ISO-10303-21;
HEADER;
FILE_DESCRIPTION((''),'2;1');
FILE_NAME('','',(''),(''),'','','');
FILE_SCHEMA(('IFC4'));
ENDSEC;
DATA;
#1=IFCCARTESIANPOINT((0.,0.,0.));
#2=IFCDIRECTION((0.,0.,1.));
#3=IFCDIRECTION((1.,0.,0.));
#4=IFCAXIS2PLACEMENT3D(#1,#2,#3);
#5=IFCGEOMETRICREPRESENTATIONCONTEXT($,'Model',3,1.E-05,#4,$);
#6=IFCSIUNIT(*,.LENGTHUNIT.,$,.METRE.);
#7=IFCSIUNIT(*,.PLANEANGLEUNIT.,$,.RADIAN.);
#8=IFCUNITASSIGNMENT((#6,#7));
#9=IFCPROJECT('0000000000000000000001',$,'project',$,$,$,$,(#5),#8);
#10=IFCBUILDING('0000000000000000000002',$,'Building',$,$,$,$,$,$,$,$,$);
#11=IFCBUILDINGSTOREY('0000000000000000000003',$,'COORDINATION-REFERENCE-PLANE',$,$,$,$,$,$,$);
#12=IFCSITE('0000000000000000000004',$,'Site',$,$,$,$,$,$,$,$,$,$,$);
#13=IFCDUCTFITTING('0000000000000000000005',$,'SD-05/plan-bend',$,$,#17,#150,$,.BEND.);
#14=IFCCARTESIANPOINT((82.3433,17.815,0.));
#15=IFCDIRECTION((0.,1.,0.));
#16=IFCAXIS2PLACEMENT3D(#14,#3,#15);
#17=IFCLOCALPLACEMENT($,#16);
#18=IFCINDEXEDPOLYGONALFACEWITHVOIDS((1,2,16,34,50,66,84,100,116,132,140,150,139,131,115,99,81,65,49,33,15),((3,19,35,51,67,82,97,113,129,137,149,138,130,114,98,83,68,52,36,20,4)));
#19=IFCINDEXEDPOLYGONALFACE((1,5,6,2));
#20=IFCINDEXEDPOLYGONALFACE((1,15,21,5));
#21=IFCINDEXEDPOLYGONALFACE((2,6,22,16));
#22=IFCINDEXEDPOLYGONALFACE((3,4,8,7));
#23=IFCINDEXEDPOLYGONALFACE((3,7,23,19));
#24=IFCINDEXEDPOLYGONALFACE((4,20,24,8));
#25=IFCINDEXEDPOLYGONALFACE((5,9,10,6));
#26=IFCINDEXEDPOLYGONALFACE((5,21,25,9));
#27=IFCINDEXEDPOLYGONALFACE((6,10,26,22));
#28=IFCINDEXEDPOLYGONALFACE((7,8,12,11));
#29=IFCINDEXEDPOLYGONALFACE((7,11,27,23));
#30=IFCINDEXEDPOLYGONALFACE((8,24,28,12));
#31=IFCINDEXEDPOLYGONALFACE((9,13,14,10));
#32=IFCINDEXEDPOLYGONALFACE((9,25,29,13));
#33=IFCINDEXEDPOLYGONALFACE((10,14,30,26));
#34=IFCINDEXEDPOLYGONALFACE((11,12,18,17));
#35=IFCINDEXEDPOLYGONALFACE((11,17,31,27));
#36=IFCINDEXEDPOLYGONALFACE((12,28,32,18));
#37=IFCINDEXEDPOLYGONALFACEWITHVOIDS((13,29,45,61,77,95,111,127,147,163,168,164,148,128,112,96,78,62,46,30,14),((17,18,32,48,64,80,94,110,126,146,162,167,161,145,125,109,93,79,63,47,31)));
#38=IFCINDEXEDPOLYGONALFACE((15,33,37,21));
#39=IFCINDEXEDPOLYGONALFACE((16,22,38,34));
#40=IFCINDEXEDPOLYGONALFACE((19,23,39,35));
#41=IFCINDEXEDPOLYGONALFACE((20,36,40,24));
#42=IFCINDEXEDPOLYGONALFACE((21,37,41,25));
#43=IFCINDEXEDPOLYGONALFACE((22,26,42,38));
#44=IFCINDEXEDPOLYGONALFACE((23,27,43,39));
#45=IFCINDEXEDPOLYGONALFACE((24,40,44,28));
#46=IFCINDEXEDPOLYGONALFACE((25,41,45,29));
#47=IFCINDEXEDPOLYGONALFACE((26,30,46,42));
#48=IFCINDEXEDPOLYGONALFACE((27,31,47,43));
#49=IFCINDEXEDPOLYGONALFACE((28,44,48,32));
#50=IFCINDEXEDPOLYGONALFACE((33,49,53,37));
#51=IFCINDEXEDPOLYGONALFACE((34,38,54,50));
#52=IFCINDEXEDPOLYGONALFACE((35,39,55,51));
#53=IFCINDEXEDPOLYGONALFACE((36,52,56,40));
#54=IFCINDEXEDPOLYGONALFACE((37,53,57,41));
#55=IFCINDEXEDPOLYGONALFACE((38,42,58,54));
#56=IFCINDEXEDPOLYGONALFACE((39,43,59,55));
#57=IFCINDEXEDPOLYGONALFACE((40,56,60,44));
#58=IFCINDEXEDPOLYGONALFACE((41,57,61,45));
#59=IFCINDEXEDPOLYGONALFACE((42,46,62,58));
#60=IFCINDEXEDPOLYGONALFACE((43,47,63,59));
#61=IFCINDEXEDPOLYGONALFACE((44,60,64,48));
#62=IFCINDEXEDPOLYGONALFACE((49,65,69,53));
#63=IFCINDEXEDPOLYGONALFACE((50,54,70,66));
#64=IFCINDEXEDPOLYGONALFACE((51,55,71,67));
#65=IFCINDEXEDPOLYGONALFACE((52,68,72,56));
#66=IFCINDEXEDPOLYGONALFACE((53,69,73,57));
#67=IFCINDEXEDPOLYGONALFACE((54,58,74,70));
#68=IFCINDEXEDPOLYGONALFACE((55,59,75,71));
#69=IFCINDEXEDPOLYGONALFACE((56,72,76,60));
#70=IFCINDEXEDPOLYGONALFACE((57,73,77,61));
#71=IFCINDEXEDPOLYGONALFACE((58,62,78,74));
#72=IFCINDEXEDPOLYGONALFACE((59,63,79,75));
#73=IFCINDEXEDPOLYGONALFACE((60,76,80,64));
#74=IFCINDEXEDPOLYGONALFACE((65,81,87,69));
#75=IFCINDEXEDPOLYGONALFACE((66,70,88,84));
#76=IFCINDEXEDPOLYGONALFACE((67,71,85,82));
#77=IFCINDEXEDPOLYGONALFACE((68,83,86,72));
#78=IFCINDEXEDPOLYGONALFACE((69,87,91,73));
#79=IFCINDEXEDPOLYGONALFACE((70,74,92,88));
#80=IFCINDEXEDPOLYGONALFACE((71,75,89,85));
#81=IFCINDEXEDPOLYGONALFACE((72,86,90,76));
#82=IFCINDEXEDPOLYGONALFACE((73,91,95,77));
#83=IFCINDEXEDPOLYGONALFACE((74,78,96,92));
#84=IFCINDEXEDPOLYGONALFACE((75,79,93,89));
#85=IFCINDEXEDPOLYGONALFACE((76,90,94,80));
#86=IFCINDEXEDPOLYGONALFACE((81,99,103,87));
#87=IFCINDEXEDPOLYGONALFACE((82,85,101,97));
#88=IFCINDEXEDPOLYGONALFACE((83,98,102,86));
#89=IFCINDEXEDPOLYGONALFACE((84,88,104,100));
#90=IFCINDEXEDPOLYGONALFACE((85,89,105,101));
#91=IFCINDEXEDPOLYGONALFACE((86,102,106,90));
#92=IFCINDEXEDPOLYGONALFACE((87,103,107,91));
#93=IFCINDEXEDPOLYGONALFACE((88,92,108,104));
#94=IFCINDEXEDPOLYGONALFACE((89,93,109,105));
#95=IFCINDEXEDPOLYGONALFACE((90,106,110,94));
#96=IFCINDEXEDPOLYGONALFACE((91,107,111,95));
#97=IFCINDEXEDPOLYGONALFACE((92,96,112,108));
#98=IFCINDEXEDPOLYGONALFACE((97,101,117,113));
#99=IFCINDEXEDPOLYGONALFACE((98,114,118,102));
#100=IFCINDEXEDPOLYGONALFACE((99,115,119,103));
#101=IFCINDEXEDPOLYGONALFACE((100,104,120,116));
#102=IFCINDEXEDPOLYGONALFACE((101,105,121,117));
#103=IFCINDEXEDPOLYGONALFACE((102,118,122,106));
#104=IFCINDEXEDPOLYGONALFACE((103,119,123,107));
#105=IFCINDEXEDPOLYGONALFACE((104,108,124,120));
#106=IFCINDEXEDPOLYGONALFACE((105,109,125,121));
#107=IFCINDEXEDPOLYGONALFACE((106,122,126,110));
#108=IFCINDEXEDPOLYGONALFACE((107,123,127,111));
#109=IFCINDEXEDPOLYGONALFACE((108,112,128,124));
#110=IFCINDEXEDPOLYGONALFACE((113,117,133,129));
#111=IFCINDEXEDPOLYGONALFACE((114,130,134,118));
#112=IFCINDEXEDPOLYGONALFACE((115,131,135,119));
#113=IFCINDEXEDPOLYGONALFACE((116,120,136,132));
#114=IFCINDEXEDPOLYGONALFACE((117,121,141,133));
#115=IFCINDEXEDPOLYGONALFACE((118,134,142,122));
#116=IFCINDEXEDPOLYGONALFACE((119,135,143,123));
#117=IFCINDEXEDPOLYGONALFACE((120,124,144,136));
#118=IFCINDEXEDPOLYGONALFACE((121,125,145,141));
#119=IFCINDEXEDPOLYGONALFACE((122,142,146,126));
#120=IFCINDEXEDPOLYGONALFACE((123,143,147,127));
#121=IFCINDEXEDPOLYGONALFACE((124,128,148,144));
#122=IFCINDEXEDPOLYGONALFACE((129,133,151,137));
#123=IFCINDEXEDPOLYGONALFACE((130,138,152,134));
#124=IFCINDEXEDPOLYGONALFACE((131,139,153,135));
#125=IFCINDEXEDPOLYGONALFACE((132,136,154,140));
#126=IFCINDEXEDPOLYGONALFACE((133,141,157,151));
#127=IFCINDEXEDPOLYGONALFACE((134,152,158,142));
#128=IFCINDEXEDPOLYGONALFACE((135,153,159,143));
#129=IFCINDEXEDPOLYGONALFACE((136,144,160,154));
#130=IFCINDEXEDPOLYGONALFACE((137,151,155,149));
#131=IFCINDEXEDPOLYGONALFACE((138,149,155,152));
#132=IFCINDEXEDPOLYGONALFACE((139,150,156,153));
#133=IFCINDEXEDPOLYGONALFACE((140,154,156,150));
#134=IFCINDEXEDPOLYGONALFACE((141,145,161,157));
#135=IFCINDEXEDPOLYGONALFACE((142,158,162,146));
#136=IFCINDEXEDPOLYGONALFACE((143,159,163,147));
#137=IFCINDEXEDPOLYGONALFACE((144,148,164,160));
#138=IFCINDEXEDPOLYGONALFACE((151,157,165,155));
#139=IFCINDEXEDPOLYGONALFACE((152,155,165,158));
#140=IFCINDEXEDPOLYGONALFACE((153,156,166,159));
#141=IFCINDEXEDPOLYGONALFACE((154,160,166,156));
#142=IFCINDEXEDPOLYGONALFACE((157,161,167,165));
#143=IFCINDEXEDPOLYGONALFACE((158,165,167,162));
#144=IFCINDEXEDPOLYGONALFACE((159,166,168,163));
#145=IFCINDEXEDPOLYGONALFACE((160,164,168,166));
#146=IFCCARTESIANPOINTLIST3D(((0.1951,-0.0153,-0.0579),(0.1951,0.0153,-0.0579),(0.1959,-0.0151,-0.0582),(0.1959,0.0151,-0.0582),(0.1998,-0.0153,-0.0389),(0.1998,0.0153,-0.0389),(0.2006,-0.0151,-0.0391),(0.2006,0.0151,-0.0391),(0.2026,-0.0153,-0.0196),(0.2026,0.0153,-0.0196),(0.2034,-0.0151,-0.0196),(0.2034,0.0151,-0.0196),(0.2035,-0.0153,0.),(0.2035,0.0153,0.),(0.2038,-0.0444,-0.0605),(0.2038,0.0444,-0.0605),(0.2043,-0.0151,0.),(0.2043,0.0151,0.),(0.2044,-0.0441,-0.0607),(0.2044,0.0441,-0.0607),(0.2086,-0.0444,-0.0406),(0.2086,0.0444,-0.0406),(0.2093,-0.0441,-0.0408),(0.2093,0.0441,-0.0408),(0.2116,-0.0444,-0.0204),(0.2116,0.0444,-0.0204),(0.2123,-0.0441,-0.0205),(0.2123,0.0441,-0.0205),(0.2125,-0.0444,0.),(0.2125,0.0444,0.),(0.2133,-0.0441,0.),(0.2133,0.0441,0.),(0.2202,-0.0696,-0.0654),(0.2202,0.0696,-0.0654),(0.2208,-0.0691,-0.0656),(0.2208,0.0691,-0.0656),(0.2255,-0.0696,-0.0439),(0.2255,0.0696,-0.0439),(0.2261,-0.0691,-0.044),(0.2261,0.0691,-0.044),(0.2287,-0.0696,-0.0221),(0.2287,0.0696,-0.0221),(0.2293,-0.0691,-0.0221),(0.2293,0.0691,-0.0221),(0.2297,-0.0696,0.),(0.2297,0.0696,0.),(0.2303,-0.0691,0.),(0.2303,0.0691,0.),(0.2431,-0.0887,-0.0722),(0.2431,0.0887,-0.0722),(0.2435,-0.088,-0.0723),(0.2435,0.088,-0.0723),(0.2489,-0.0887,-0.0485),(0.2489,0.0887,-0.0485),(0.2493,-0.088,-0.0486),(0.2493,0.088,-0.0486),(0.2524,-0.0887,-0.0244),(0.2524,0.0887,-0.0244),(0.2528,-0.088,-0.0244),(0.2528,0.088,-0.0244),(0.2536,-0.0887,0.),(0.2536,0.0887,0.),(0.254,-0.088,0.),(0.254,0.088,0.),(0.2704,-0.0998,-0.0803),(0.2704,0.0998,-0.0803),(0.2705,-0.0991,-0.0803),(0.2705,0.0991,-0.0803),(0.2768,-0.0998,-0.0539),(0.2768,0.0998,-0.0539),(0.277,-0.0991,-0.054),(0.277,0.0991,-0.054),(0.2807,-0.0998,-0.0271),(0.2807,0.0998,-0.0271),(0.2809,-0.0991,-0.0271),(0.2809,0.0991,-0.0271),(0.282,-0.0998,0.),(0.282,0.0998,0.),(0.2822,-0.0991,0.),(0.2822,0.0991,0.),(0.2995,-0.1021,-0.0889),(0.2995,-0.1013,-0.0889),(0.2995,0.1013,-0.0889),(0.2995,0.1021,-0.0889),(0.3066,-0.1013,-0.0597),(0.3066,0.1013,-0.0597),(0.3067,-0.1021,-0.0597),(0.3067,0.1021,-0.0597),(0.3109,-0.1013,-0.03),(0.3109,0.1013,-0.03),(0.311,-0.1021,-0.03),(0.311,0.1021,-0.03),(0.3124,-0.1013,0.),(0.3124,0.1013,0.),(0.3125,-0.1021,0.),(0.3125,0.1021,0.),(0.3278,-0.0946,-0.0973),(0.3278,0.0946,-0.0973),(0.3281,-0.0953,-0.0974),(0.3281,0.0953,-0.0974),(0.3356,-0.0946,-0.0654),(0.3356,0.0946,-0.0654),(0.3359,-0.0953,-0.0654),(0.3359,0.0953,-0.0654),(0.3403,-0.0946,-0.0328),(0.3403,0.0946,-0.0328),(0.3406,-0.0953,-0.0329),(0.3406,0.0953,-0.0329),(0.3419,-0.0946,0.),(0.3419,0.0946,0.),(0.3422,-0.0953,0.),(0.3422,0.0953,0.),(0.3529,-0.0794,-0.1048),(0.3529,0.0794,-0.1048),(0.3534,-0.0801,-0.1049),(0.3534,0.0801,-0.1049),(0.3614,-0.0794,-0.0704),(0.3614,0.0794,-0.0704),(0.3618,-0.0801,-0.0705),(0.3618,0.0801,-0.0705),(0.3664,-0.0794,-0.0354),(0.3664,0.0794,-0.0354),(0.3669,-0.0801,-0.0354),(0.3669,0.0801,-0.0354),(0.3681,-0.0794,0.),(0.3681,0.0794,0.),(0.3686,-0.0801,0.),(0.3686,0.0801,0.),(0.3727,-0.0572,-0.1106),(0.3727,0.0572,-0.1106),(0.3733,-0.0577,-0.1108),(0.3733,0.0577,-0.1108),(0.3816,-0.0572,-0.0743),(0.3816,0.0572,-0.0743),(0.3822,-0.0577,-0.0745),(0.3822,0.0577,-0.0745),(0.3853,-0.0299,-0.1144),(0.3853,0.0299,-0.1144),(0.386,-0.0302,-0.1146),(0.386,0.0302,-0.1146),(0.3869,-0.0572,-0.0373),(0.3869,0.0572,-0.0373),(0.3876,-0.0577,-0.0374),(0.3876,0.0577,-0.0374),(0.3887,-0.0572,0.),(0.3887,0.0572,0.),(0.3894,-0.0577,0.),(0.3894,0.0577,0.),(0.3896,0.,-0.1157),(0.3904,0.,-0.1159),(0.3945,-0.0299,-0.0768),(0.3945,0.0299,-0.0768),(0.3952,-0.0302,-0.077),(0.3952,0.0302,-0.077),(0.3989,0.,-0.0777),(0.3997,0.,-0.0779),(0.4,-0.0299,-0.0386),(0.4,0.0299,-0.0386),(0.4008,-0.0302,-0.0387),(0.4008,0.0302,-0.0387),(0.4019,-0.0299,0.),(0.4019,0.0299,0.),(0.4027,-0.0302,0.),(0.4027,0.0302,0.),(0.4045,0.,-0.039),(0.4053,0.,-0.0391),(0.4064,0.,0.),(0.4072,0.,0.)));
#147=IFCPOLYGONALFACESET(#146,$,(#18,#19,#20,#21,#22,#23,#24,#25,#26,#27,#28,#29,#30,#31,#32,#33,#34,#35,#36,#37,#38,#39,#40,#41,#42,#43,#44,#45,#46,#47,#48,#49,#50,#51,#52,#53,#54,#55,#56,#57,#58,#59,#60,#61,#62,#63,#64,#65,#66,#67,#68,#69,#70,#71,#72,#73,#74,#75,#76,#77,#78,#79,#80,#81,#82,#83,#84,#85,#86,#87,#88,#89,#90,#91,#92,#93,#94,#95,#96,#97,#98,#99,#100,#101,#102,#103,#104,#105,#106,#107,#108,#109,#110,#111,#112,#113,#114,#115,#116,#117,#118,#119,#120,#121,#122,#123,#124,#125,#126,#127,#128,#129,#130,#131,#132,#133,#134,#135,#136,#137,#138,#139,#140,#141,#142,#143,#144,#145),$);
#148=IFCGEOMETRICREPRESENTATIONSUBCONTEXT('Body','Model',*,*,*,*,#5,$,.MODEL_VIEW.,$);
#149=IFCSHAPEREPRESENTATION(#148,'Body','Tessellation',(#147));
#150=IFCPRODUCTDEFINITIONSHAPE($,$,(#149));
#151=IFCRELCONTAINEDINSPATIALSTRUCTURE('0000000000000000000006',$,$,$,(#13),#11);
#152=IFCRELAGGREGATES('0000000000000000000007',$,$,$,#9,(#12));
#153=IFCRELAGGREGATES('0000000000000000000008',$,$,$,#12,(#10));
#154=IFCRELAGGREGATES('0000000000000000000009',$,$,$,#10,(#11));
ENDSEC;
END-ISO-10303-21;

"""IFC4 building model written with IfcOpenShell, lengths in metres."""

from ifc_helpers import new_model, entity, si_unit, frame, origin_with_axes, place, context, subcontext, project, spatial, element, save


model = new_model("IFC4")

# Units and contexts
model_context_1 = context("Model", 3, precision=1e-05, world=origin_with_axes())
body_context_1 = subcontext(model_context_1, "Body", "Model", "MODEL_VIEW")
ifc_project = project(units=[si_unit("LENGTHUNIT", "METRE"), si_unit("PLANEANGLEUNIT", "RADIAN")], contexts=[model_context_1])

# Site, building, storey
site = spatial("IfcSite", under=ifc_project, Name="Site")
building = spatial("IfcBuilding", under=site, Name="Building")
storey = spatial("IfcBuildingStorey", under=building, Name="COORDINATION-REFERENCE-PLANE")

# Duct fitting
duct_fitting_1_placement = place(None, frame((82.3433, 17.815, 0.0), z_axis=(1.0, 0.0, 0.0), x_axis=(0.0, 1.0, 0.0)))
element("IfcDuctFitting", 1, at=duct_fitting_1_placement, inside=storey, Name="SD-05/plan-bend", PredefinedType="BEND", context=body_context_1, shape_type="SweptSolid", body=[
    entity("IfcRevolvedAreaSolid", entity("IfcCircleHollowProfileDef", "AREA", None, entity("IfcAxis2Placement2D", entity("IfcCartesianPoint", [0.3048, 0.0])), 0.1024, 0.0008), entity("IfcAxis2Placement3D", entity("IfcCartesianPoint", [0.0, 0.0, 0.0]), entity("IfcDirection", [0.0, 0.0, 1.0]), entity("IfcDirection", [1.0, 0.0, 0.0])), entity("IfcAxis1Placement", entity("IfcCartesianPoint", [0.0, 0.0, 0.0]), entity("IfcDirection", [0.0, 1.0, 0.0])), 0.288593),
])

save(model, "model.ifc")
